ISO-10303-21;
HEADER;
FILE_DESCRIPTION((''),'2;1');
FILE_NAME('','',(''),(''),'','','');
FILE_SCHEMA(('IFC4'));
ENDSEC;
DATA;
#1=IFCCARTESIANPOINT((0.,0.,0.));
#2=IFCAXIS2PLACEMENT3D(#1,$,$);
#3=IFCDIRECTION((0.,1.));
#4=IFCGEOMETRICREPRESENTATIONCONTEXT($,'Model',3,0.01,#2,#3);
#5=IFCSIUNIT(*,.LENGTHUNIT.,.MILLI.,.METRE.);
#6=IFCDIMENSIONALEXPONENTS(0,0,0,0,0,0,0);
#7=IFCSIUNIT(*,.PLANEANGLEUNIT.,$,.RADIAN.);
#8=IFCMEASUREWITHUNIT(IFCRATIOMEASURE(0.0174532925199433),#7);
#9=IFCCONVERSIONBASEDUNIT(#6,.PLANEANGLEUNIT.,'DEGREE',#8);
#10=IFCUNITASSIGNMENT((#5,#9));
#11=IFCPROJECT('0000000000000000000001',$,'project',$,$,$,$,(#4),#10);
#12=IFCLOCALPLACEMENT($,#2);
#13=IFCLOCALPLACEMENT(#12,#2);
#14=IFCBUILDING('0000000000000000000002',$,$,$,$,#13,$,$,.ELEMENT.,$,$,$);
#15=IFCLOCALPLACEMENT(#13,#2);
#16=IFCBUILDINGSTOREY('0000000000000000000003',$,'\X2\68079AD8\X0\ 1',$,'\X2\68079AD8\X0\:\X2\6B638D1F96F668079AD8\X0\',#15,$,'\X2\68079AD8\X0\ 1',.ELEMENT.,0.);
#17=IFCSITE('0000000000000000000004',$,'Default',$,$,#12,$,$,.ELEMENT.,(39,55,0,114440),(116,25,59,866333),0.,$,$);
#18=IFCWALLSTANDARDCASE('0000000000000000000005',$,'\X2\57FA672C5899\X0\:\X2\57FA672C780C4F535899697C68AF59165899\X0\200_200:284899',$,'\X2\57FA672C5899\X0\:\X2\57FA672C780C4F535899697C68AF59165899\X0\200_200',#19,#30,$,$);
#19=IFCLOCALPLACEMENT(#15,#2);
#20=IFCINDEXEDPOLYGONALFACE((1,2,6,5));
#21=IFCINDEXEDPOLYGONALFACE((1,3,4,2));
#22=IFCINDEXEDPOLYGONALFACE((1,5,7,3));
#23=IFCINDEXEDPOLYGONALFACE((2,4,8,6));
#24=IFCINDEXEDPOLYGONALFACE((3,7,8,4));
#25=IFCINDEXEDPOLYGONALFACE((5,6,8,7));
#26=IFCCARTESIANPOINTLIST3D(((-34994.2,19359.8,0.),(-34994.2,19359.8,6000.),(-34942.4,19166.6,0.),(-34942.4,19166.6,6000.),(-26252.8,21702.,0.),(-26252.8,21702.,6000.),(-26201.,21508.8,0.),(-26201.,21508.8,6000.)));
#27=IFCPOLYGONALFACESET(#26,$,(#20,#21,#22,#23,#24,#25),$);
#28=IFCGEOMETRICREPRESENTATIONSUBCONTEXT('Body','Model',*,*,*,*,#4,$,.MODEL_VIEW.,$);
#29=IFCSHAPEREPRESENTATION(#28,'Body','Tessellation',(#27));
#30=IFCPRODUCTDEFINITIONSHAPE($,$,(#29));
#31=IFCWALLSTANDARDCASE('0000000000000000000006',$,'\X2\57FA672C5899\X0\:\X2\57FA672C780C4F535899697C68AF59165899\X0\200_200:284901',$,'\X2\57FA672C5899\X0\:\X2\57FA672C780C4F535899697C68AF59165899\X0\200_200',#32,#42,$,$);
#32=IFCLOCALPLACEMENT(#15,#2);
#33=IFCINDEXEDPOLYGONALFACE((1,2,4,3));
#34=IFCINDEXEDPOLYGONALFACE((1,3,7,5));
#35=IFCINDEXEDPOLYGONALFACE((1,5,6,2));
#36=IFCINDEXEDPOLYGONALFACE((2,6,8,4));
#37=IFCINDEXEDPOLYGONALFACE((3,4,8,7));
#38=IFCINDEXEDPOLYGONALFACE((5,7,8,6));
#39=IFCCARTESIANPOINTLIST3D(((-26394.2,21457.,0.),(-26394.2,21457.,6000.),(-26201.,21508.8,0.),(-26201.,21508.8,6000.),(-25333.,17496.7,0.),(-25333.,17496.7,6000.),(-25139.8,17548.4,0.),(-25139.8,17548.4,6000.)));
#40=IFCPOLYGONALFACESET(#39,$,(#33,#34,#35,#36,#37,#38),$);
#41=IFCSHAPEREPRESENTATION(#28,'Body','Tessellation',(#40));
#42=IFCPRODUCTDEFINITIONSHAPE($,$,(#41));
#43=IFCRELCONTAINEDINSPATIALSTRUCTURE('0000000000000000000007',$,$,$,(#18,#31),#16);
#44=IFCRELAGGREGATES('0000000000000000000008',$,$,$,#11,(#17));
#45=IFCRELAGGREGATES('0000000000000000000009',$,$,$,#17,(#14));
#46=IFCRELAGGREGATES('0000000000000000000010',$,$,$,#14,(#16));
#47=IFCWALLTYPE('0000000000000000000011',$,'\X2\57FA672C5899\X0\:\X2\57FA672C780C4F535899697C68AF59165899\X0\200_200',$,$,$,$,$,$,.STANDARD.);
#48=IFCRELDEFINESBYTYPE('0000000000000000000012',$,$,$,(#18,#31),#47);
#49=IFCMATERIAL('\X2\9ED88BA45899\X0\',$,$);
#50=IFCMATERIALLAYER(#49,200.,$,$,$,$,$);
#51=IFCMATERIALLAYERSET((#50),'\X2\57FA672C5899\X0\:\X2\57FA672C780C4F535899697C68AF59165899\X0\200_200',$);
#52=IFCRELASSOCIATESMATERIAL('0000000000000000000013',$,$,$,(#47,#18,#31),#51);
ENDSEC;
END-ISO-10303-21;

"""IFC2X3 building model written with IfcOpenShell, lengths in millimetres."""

from ifc_helpers import new_model, entity, si_unit, converted_unit, direction, frame, frame_2d, origin, place, context, subcontext, project, spatial, rectangle, extrude, material, layer, layer_set, layer_usage, type_object, element, save


model = new_model("IFC2X3")

# Units and contexts
model_context = context("Model", 3, precision=0.01, world=origin(), true_north=direction((0.0, 1.0)))
body_context = subcontext(model_context, "Body", "Model", "MODEL_VIEW")
ifc_project = project(units=[si_unit("LENGTHUNIT", "METRE", prefix="MILLI"), converted_unit("PLANEANGLEUNIT", "DEGREE", entity("IfcRatioMeasure", 0.0174532925199433), si_unit("PLANEANGLEUNIT", "RADIAN"), dimensions=[0, 0, 0, 0, 0, 0, 0])], contexts=[model_context])

# Site, building, storey
site_placement = place(None, origin())
site = spatial("IfcSite", under=ifc_project, at=site_placement, Name="Default", CompositionType="ELEMENT", RefLatitude=(39, 55, 0, 114440), RefLongitude=(116, 25, 59, 866333), RefElevation=0.0)
building_placement = place(site_placement, origin())
building = spatial("IfcBuilding", under=site, at=building_placement, CompositionType="ELEMENT")
storey_placement = place(building_placement, origin())
storey = spatial("IfcBuildingStorey", under=building, at=storey_placement, Name="标高 1", ObjectType="标高:正负零标高", LongName="标高 1", CompositionType="ELEMENT", Elevation=0.0)

# Walls
ifc_material = material(Name="默认墙")
ifc_layer_1 = layer(ifc_material, 200.0)
ifc_layer_set_1 = layer_set([ifc_layer_1], Name="基本墙:基本砌体墙楼梯外墙200_200")
ifc_layer_usage_1 = layer_usage(ifc_layer_set_1, "AXIS2", "NEGATIVE", 100.0)
wall_type_1 = type_object("IfcWallType", Name="基本墙:基本砌体墙楼梯外墙200_200", PredefinedType="STANDARD", material=ifc_layer_set_1)
wall_1_placement = place(building_placement, frame((-26226.9, 21605.4, 0.0), z_axis=(0.0, 0.0, 1.0), x_axis=(-0.965926, -0.258819, 0.0)))
element("IfcWallStandardCase", 1, at=wall_1_placement, inside=storey, type_object=wall_type_1, material=ifc_layer_usage_1, Name="基本墙:基本砌体墙楼梯外墙200_200:284899", ObjectType="基本墙:基本砌体墙楼梯外墙200_200", context=body_context, shape_type="SweptSolid", body=[
    extrude(rectangle(XDim=9049.7, YDim=200.0, at=frame_2d((4524.9, 0.0), x_axis=(-1.0, 0.0))), origin(), (0.0, 0.0, 1.0), 6000.0),
])
ifc_layer_usage_2 = layer_usage(ifc_layer_set_1, "AXIS2", "NEGATIVE", 100.0)
wall_2_placement = place(building_placement, frame((-25236.4, 17522.5, 0.0), z_axis=(0.0, 0.0, 1.0), x_axis=(-0.258819, 0.965926, 0.0)))
element("IfcWallStandardCase", 2, at=wall_2_placement, inside=storey, type_object=wall_type_1, material=ifc_layer_usage_2, Name="基本墙:基本砌体墙楼梯外墙200_200:284901", ObjectType="基本墙:基本砌体墙楼梯外墙200_200", context=body_context, shape_type="SweptSolid", body=[
    extrude(rectangle(XDim=4100.1, YDim=200.0, at=frame_2d((2050.0, 0.0), x_axis=(-1.0, 0.0))), origin(), (0.0, 0.0, 1.0), 6000.0),
])

save(model, "model.ifc")
